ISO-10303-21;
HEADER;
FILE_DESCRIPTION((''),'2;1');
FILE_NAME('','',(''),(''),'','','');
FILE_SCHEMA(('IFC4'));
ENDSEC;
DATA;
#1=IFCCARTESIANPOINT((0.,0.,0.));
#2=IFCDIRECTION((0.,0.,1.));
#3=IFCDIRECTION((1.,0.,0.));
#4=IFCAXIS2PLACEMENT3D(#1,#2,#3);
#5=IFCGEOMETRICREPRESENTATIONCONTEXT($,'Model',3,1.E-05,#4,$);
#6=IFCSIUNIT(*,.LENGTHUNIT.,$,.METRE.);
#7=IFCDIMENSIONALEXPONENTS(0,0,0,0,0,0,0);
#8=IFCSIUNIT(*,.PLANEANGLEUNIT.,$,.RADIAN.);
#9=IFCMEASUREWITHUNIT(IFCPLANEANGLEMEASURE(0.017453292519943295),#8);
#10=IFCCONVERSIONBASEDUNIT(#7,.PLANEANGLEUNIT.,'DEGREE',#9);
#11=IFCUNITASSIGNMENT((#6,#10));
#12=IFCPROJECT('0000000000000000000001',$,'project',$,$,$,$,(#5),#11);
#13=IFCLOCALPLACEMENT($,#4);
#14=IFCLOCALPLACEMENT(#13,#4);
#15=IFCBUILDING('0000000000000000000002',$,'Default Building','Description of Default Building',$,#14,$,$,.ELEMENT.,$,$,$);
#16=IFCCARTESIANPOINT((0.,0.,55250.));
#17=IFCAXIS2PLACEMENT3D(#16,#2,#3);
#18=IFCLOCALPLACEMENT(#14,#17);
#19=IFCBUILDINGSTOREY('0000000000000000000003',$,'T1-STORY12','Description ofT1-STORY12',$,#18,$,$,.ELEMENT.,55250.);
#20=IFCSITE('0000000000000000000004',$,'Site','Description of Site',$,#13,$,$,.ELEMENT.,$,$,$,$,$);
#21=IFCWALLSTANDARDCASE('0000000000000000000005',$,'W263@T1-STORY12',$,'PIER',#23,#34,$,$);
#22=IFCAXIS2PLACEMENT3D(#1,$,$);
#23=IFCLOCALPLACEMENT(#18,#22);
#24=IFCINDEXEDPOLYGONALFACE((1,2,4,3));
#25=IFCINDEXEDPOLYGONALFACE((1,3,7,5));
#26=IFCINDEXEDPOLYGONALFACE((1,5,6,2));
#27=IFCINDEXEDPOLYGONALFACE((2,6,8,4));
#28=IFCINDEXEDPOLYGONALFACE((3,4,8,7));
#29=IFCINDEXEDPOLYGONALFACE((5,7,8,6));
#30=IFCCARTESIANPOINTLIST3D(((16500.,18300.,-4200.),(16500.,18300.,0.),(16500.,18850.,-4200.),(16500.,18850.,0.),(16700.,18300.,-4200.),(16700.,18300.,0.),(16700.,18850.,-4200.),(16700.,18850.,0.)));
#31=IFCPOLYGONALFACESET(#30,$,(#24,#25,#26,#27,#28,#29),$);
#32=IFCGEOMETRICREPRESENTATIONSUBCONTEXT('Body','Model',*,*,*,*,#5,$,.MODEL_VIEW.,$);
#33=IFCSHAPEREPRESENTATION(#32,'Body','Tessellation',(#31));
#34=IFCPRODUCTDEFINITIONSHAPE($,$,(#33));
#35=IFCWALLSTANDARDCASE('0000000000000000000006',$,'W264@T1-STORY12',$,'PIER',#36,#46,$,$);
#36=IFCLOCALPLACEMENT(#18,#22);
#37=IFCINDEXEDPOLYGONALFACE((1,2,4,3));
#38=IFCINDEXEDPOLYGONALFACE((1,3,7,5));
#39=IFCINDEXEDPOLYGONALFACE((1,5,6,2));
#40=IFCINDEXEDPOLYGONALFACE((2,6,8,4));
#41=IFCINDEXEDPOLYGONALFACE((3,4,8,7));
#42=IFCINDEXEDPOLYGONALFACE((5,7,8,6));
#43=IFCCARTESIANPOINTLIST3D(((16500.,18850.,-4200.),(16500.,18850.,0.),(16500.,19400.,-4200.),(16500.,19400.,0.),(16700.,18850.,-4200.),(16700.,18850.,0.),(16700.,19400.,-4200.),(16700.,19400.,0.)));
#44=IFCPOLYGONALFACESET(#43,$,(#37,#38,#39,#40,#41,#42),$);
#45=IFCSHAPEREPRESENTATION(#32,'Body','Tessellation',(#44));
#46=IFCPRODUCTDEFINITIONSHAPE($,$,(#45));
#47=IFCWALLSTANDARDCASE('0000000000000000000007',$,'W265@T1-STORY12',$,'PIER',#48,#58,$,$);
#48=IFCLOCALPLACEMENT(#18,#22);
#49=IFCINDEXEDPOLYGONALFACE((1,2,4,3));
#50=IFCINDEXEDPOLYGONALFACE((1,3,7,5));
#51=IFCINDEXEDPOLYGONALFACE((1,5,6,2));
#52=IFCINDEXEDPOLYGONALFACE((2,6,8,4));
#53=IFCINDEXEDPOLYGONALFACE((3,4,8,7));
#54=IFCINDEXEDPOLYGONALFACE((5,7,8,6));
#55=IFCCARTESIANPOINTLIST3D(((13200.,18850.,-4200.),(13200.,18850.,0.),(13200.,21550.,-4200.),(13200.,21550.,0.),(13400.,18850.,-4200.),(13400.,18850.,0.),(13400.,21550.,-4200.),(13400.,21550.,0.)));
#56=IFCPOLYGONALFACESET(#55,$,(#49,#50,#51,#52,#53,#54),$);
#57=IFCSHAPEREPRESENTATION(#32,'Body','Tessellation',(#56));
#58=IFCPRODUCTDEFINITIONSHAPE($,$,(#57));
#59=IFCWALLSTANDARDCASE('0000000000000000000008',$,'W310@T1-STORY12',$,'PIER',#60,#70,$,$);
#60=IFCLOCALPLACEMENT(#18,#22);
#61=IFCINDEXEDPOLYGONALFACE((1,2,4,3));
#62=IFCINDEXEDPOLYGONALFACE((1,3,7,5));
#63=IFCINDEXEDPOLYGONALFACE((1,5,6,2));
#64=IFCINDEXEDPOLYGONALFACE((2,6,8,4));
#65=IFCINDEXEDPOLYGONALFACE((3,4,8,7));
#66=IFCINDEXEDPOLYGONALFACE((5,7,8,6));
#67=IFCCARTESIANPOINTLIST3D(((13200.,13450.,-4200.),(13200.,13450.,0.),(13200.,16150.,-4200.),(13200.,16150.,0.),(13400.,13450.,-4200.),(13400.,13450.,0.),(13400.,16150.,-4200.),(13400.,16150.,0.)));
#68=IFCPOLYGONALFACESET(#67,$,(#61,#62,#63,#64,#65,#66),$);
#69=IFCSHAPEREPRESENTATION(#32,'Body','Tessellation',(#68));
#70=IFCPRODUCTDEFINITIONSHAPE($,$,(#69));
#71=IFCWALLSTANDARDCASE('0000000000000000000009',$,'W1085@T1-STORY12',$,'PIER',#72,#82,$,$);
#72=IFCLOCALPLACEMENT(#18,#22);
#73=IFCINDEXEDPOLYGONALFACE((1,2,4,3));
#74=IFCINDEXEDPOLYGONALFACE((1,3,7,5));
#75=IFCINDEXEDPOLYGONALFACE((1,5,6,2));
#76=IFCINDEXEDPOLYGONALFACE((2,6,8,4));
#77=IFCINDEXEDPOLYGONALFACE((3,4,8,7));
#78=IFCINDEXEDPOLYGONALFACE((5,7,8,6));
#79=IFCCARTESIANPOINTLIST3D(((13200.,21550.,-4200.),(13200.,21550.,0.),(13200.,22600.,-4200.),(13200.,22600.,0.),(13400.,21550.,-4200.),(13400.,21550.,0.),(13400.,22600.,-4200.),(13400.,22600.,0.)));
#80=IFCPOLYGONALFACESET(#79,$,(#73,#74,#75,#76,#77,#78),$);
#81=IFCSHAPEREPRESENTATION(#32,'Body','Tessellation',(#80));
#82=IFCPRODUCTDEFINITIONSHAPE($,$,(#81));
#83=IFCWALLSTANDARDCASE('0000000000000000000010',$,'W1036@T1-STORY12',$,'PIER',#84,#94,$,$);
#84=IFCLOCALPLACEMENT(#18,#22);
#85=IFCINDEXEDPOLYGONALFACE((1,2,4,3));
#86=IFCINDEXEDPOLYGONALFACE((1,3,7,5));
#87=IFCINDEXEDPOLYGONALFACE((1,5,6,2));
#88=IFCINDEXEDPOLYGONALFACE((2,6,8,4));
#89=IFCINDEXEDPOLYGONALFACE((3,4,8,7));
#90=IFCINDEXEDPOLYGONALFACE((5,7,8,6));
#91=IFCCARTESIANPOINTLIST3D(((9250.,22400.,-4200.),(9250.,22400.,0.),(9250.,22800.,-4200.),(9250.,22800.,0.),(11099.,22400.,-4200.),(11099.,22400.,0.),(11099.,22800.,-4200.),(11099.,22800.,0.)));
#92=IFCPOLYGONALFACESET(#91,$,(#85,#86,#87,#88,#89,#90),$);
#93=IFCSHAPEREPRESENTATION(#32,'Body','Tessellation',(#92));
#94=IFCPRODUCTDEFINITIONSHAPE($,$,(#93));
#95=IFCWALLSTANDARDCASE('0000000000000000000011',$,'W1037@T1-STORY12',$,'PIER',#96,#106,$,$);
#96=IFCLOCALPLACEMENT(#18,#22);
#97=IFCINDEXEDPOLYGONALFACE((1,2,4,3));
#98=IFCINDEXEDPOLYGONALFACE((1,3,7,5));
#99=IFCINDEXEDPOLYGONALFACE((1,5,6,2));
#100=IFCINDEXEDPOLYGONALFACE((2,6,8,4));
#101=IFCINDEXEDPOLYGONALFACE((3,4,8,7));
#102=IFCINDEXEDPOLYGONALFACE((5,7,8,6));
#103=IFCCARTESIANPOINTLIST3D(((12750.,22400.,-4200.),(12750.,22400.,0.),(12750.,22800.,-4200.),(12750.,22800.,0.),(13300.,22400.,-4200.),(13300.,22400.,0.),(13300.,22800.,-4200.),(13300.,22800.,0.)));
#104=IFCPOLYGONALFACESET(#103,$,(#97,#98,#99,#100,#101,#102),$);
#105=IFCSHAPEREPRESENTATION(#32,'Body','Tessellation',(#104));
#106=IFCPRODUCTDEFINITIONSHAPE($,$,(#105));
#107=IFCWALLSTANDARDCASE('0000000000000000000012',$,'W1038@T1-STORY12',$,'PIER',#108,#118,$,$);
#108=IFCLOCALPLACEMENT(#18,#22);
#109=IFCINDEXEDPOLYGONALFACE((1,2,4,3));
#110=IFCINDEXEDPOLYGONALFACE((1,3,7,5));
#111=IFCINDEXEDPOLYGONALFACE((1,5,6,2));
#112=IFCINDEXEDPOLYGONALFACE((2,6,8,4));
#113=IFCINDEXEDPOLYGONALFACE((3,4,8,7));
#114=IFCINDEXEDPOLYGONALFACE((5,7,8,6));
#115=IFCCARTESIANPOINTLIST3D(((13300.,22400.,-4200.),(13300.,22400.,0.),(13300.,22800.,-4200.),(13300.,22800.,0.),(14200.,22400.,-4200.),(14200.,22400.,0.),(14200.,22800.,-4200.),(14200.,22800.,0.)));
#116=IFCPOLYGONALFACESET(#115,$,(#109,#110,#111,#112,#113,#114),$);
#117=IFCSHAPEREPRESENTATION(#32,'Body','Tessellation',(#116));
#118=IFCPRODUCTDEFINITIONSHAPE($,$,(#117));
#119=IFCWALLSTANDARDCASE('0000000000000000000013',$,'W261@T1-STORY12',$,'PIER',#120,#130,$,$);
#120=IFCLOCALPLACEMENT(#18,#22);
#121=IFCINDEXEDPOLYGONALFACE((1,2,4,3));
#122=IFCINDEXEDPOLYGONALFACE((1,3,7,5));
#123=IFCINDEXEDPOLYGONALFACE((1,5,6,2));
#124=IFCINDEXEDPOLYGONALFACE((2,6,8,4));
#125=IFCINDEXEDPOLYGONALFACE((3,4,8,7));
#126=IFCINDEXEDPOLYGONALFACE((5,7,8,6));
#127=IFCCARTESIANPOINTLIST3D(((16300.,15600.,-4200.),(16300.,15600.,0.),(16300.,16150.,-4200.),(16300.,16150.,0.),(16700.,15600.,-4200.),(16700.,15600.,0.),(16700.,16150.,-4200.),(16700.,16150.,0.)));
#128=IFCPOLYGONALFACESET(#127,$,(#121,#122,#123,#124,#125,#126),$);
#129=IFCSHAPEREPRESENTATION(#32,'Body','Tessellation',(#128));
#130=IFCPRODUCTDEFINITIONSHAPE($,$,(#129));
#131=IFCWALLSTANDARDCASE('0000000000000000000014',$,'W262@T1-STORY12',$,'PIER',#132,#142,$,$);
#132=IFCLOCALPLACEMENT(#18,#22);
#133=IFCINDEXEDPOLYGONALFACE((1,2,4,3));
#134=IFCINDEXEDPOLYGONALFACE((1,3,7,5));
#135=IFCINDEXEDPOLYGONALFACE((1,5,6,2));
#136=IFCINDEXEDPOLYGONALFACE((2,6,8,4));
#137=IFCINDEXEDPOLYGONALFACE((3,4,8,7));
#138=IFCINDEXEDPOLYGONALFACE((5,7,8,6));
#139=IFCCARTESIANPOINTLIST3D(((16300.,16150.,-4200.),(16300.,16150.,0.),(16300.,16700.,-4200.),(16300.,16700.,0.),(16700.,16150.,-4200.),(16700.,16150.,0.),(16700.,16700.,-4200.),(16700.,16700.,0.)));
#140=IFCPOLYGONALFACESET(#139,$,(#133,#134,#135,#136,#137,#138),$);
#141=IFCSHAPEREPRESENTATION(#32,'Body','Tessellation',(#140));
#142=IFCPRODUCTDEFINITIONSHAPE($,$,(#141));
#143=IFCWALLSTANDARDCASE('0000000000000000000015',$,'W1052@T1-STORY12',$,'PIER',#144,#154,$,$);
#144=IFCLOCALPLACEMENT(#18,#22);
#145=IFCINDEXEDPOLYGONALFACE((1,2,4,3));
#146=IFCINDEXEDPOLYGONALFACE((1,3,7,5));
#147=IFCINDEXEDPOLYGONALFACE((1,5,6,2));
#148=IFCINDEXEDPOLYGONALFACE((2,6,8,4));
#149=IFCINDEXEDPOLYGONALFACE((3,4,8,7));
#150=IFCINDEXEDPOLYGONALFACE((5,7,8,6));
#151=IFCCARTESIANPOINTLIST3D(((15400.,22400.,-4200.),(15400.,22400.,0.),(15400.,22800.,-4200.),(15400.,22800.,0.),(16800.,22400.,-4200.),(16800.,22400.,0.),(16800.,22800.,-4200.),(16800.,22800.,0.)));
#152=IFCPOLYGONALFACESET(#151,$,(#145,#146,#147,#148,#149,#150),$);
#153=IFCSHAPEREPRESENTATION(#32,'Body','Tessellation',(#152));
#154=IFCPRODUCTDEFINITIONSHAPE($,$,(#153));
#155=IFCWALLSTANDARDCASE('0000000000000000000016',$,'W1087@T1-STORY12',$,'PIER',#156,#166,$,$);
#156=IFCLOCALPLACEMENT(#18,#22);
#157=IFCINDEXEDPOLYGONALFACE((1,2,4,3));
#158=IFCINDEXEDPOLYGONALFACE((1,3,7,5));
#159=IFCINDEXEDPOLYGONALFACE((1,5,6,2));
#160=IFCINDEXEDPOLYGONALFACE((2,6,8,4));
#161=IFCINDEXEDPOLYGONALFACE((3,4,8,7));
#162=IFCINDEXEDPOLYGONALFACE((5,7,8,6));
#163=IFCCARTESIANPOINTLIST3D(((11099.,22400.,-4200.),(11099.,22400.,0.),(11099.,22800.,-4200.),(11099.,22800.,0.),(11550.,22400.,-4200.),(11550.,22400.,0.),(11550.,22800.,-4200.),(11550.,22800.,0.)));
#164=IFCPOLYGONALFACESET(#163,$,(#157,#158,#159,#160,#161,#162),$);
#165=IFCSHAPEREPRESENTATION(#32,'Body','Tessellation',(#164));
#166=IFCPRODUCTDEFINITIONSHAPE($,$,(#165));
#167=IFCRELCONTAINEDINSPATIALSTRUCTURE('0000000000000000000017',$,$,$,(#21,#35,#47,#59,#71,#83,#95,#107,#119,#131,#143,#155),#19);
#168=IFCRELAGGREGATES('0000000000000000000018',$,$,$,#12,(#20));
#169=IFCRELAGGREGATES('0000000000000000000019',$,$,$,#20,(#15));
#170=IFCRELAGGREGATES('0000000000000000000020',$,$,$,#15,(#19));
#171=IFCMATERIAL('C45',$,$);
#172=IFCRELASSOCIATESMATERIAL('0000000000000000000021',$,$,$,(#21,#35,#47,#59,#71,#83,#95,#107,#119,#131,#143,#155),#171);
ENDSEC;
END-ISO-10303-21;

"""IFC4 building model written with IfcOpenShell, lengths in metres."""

from ifc_helpers import new_model, entity, si_unit, converted_unit, frame, origin_with_axes, place, context, subcontext, project, spatial, indexed_curve, outline, extrude, material, element, save


model = new_model("IFC4")

# Units and contexts
model_context = context("Model", 3, precision=1e-05, world=origin_with_axes())
body_context = subcontext(model_context, "Body", "Model", "MODEL_VIEW")
ifc_project = project(units=[si_unit("LENGTHUNIT", "METRE"), converted_unit("PLANEANGLEUNIT", "DEGREE", entity("IfcPlaneAngleMeasure", 0.017453292519943295), si_unit("PLANEANGLEUNIT", "RADIAN"), dimensions=[0, 0, 0, 0, 0, 0, 0])], contexts=[model_context])

# Site, building, storey
site_placement = place(None, origin_with_axes())
site = spatial("IfcSite", under=ifc_project, at=site_placement, Name="Site", Description="Description of Site", CompositionType="ELEMENT")
building_placement = place(site_placement, origin_with_axes())
building = spatial("IfcBuilding", under=site, at=building_placement, Name="Default Building", Description="Description of Default Building", CompositionType="ELEMENT")
storey_placement = place(building_placement, frame((0.0, 0.0, 55250.0), z_axis=(0.0, 0.0, 1.0), x_axis=(1.0, 0.0, 0.0)))
storey = spatial("IfcBuildingStorey", under=building, at=storey_placement, Name="T1-STORY12", Description="Description ofT1-STORY12", CompositionType="ELEMENT", Elevation=55250.0)

# Shared definitions
ifc_material_1 = material(Name="C45")

# Walls
for number, where, z_axis, x_axis, name in (
    (1, (16600.0, 18300.0, -4200.0), (0.0, 0.0, 1.0), (0.0, 1.0, 0.0), "W263@T1-STORY12"),
    (2, (16600.0, 18850.0, -4200.0), (0.0, 0.0, 1.0), (0.0, 1.0, 0.0), "W264@T1-STORY12"),
):
    element("IfcWallStandardCase", number, at=place(storey_placement, frame(where, z_axis=z_axis, x_axis=x_axis)), inside=storey, material=ifc_material_1, Name=name, ObjectType="PIER", context=body_context, shape_type="SweptSolid", body=[
        extrude(outline(indexed_curve([(0.0, -100.0), (0.0, 100.0), (550.0, 100.0), (550.0, -100.0), (0.0, -100.0)], self_intersect=False)), origin_with_axes(), (0.0, 0.0, 1.0), 4200.0),
    ])
for number, where, z_axis, x_axis, name in (
    (3, (13300.0, 18850.0, -4200.0), (0.0, 0.0, 1.0), (0.0, 1.0, 0.0), "W265@T1-STORY12"),
    (4, (13300.0, 13450.0, -4200.0), (0.0, 0.0, 1.0), (0.0, 1.0, 0.0), "W310@T1-STORY12"),
):
    element("IfcWallStandardCase", number, at=place(storey_placement, frame(where, z_axis=z_axis, x_axis=x_axis)), inside=storey, material=ifc_material_1, Name=name, ObjectType="PIER", context=body_context, shape_type="SweptSolid", body=[
        extrude(outline(indexed_curve([(0.0, -100.0), (0.0, 100.0), (2700.0, 100.0), (2700.0, -100.0), (0.0, -100.0)], self_intersect=False)), origin_with_axes(), (0.0, 0.0, 1.0), 4200.0),
    ])
wall_1_placement = place(storey_placement, frame((13300.0, 21550.0, -4200.0), z_axis=(0.0, 0.0, 1.0), x_axis=(0.0, 1.0, 0.0)))
element("IfcWallStandardCase", 5, at=wall_1_placement, inside=storey, material=ifc_material_1, Name="W1085@T1-STORY12", ObjectType="PIER", context=body_context, shape_type="SweptSolid", body=[
    extrude(outline(indexed_curve([(0.0, -100.0), (0.0, 100.0), (1050.0, 100.0), (1050.0, -100.0), (0.0, -100.0)], self_intersect=False)), origin_with_axes(), (0.0, 0.0, 1.0), 4200.0),
])
wall_2_placement = place(storey_placement, frame((9250.0, 22600.0, -4200.0), z_axis=(0.0, 0.0, 1.0), x_axis=(1.0, 0.0, 0.0)))
element("IfcWallStandardCase", 6, at=wall_2_placement, inside=storey, material=ifc_material_1, Name="W1036@T1-STORY12", ObjectType="PIER", context=body_context, shape_type="SweptSolid", body=[
    extrude(outline(indexed_curve([(0.0, -200.0), (0.0, 200.0), (1849.0, 200.0), (1849.0, -200.0), (0.0, -200.0)], self_intersect=False)), origin_with_axes(), (0.0, 0.0, 1.0), 4200.0),
])
wall_3_placement = place(storey_placement, frame((12750.0, 22600.0, -4200.0), z_axis=(0.0, 0.0, 1.0), x_axis=(1.0, 0.0, 0.0)))
element("IfcWallStandardCase", 7, at=wall_3_placement, inside=storey, material=ifc_material_1, Name="W1037@T1-STORY12", ObjectType="PIER", context=body_context, shape_type="SweptSolid", body=[
    extrude(outline(indexed_curve([(0.0, -200.0), (0.0, 200.0), (550.0, 200.0), (550.0, -200.0), (0.0, -200.0)], self_intersect=False)), origin_with_axes(), (0.0, 0.0, 1.0), 4200.0),
])
wall_4_placement = place(storey_placement, frame((13300.0, 22600.0, -4200.0), z_axis=(0.0, 0.0, 1.0), x_axis=(1.0, 0.0, 0.0)))
element("IfcWallStandardCase", 8, at=wall_4_placement, inside=storey, material=ifc_material_1, Name="W1038@T1-STORY12", ObjectType="PIER", context=body_context, shape_type="SweptSolid", body=[
    extrude(outline(indexed_curve([(0.0, -200.0), (0.0, 200.0), (900.0, 200.0), (900.0, -200.0), (0.0, -200.0)], self_intersect=False)), origin_with_axes(), (0.0, 0.0, 1.0), 4200.0),
])
for number, where, z_axis, x_axis, name in (
    (9, (16500.0, 15600.0, -4200.0), (0.0, 0.0, 1.0), (0.0, 1.0, 0.0), "W261@T1-STORY12"),
    (10, (16500.0, 16150.0, -4200.0), (0.0, 0.0, 1.0), (0.0, 1.0, 0.0), "W262@T1-STORY12"),
):
    element("IfcWallStandardCase", number, at=place(storey_placement, frame(where, z_axis=z_axis, x_axis=x_axis)), inside=storey, material=ifc_material_1, Name=name, ObjectType="PIER", context=body_context, shape_type="SweptSolid", body=[
        extrude(outline(indexed_curve([(0.0, -200.0), (0.0, 200.0), (550.0, 200.0), (550.0, -200.0), (0.0, -200.0)], self_intersect=False)), origin_with_axes(), (0.0, 0.0, 1.0), 4200.0),
    ])
wall_5_placement = place(storey_placement, frame((15400.0, 22600.0, -4200.0), z_axis=(0.0, 0.0, 1.0), x_axis=(1.0, 0.0, 0.0)))
element("IfcWallStandardCase", 11, at=wall_5_placement, inside=storey, material=ifc_material_1, Name="W1052@T1-STORY12", ObjectType="PIER", context=body_context, shape_type="SweptSolid", body=[
    extrude(outline(indexed_curve([(0.0, -200.0), (0.0, 200.0), (1400.0, 200.0), (1400.0, -200.0), (0.0, -200.0)], self_intersect=False)), origin_with_axes(), (0.0, 0.0, 1.0), 4200.0),
])
wall_6_placement = place(storey_placement, frame((11099.0, 22600.0, -4200.0), z_axis=(0.0, 0.0, 1.0), x_axis=(1.0, 0.0, 0.0)))
element("IfcWallStandardCase", 12, at=wall_6_placement, inside=storey, material=ifc_material_1, Name="W1087@T1-STORY12", ObjectType="PIER", context=body_context, shape_type="SweptSolid", body=[
    extrude(outline(indexed_curve([(0.0, -200.0), (0.0, 200.0), (451.0, 200.0), (451.0, -200.0), (0.0, -200.0)], self_intersect=False)), origin_with_axes(), (0.0, 0.0, 1.0), 4200.0),
])

save(model, "model.ifc")
